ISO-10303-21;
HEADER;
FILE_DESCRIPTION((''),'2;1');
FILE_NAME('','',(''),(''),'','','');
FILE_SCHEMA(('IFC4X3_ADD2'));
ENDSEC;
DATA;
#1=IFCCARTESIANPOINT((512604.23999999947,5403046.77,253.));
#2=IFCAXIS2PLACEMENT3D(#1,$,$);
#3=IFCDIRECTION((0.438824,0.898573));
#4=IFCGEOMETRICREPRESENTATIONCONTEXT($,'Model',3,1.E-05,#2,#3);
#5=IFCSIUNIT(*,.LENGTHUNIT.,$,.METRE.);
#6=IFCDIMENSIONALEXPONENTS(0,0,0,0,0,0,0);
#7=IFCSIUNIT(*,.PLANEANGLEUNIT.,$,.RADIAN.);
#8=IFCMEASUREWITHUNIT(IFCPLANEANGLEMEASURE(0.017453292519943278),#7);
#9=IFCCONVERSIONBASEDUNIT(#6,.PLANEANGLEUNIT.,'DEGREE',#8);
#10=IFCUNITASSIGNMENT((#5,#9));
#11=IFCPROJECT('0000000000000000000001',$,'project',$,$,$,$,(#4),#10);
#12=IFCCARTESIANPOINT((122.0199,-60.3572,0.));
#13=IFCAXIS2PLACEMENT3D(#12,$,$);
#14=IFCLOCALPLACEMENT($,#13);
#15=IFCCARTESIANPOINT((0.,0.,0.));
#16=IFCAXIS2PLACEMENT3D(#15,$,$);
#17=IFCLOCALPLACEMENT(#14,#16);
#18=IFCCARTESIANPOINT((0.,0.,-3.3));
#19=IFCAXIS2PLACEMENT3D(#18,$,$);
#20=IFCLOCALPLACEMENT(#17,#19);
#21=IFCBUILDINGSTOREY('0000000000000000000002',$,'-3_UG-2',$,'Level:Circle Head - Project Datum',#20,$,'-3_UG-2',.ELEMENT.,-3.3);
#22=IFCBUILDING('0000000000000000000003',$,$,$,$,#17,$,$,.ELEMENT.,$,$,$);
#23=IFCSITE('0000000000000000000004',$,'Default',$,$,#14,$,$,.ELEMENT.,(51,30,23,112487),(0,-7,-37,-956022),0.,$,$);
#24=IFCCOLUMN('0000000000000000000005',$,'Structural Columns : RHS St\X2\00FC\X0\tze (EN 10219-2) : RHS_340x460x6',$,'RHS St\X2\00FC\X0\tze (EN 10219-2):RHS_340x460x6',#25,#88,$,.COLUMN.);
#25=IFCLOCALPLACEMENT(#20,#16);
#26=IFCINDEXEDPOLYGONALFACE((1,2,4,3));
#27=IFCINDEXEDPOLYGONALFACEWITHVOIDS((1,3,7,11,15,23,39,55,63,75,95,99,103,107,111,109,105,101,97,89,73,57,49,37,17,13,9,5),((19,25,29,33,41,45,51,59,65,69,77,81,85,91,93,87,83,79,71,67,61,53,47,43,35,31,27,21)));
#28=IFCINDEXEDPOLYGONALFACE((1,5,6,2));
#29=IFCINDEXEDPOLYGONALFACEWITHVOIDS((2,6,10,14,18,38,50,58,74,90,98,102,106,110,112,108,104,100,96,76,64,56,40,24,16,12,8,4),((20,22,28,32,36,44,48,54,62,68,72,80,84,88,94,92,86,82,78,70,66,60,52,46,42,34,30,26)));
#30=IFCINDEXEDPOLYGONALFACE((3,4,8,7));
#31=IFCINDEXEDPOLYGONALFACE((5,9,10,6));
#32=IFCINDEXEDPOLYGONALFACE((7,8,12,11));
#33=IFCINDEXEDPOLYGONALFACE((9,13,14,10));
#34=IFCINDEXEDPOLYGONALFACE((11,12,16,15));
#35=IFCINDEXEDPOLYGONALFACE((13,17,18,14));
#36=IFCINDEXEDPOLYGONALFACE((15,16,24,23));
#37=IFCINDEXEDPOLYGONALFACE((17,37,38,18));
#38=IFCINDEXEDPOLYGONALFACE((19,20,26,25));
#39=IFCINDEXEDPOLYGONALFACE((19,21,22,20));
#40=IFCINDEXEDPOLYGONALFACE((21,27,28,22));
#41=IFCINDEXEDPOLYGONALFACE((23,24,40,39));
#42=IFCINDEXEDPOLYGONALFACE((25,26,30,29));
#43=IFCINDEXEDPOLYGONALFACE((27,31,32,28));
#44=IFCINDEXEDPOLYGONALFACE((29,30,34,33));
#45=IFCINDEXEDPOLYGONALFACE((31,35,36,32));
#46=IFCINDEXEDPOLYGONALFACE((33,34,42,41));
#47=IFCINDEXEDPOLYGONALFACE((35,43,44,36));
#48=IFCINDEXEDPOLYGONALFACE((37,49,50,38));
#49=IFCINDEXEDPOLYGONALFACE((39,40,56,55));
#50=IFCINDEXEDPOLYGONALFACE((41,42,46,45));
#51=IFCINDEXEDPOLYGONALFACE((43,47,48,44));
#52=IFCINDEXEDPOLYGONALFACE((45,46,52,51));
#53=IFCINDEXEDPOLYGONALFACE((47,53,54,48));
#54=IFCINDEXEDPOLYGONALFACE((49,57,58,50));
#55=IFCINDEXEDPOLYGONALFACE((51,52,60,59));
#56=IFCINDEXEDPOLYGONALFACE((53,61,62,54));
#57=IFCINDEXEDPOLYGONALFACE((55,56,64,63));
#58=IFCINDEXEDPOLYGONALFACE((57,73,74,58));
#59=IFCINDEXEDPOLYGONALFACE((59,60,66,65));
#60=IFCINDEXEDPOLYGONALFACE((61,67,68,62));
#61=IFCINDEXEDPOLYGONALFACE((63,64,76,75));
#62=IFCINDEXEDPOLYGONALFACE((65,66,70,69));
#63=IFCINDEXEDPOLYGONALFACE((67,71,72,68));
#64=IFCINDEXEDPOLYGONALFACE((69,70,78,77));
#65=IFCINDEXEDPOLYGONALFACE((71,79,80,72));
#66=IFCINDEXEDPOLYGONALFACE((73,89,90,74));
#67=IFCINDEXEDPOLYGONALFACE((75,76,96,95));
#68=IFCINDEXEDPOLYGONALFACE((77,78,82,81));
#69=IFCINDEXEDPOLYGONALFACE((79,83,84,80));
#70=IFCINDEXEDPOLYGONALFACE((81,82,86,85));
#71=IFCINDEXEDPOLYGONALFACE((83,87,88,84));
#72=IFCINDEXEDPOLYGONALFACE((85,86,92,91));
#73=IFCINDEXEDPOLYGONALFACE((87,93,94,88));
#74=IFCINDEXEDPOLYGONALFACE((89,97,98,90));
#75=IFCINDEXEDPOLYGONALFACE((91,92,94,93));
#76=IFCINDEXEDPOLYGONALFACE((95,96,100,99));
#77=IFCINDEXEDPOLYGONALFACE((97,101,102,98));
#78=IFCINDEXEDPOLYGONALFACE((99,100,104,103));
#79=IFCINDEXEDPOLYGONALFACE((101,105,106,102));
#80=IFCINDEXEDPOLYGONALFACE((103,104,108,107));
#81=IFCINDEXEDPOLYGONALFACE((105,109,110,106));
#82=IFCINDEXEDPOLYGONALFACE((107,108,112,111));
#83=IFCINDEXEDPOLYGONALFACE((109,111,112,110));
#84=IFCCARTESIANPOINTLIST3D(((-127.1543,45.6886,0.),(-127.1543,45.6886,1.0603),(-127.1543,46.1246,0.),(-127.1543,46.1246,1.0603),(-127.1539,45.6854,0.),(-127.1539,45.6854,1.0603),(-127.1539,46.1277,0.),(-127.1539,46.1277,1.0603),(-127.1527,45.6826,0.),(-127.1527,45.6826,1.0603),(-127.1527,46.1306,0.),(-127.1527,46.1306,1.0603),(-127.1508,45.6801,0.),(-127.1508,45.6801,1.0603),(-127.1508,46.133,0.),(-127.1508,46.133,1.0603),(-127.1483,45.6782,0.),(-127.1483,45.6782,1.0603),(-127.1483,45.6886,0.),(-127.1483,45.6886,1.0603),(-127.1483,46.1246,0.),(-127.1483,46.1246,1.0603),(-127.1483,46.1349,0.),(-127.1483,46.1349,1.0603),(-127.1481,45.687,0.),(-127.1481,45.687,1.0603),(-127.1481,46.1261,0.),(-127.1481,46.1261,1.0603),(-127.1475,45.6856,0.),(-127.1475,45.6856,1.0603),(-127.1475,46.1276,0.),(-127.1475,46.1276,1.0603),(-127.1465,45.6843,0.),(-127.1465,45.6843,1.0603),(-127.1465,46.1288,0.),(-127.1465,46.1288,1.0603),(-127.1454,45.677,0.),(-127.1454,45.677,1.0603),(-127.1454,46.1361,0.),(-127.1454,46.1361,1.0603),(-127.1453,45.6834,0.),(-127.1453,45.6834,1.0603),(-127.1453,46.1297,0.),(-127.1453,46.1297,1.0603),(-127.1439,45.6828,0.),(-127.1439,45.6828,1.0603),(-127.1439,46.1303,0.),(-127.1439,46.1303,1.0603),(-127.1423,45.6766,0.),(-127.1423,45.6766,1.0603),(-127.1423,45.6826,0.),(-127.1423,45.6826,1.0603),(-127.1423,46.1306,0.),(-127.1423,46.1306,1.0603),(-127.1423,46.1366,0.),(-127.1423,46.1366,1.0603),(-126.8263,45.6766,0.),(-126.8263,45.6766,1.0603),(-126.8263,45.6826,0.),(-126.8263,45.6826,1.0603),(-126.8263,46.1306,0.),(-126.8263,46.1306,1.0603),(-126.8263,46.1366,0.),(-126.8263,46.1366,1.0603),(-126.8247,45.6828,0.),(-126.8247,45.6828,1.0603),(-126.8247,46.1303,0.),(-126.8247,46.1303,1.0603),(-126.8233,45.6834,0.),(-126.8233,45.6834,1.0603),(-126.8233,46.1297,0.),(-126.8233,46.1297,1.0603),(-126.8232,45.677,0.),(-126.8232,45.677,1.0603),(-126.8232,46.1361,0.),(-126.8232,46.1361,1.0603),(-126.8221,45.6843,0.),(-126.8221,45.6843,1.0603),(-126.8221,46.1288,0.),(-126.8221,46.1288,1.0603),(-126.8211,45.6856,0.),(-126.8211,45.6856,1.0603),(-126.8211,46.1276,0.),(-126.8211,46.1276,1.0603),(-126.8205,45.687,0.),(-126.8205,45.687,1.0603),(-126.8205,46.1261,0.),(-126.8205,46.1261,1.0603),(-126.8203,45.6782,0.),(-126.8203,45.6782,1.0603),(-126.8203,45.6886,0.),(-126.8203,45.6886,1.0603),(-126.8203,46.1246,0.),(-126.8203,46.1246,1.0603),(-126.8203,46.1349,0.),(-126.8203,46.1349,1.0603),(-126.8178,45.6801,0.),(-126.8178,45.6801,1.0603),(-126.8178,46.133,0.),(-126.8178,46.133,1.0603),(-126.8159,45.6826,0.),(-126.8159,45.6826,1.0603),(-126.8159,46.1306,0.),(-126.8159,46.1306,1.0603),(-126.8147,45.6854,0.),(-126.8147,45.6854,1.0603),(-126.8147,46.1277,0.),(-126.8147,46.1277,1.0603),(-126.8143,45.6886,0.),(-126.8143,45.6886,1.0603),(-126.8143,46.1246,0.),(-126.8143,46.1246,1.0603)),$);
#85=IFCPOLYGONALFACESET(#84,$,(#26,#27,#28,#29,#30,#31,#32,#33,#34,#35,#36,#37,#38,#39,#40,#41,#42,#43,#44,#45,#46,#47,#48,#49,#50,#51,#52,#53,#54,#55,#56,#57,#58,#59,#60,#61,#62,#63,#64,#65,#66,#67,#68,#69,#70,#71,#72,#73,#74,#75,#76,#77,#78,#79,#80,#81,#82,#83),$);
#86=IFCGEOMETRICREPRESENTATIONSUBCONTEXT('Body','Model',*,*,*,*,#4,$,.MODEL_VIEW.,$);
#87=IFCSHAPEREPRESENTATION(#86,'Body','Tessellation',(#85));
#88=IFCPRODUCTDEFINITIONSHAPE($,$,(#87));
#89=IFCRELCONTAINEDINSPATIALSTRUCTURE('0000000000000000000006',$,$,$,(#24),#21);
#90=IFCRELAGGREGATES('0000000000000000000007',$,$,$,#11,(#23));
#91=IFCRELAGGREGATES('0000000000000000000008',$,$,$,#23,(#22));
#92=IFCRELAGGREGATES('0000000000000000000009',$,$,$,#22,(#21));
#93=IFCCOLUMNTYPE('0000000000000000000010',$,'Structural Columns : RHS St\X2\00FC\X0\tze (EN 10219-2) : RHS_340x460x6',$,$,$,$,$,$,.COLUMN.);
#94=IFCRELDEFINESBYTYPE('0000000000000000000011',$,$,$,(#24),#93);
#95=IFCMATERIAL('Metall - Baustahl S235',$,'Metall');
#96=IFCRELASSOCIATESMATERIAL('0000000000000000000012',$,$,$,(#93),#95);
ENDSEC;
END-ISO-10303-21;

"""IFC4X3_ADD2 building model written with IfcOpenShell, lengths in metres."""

from ifc_helpers import new_model, entity, si_unit, converted_unit, direction, frame, frame_2d, origin, place, context, subcontext, project, spatial, polyline, circle_curve, parameter, trimmed, segment, composite_curve, outline, extrude, source, transform, mapped, material, material_profile, profile_set, type_object, type_shapes, element, save


model = new_model("IFC4X3_ADD2")

# Units and contexts
model_context = context("Model", 3, precision=1e-05, world=frame((512604.23999999947, 5403046.77, 253.0)), true_north=direction((0.438824, 0.898573)))
body_context = subcontext(model_context, "Body", "Model", "MODEL_VIEW")
ifc_project = project(units=[si_unit("LENGTHUNIT", "METRE"), converted_unit("PLANEANGLEUNIT", "DEGREE", entity("IfcPlaneAngleMeasure", 0.017453292519943278), si_unit("PLANEANGLEUNIT", "RADIAN"), dimensions=[0, 0, 0, 0, 0, 0, 0])], contexts=[model_context])

# Site, building, storey
site_placement = place(None, frame((122.0199, -60.3572, 0.0)))
site = spatial("IfcSite", under=ifc_project, at=site_placement, Name="Default", CompositionType="ELEMENT", RefLatitude=(51, 30, 23, 112487), RefLongitude=(0, -7, -37, -956022), RefElevation=0.0)
building_placement = place(site_placement, origin())
building = spatial("IfcBuilding", under=site, at=building_placement, CompositionType="ELEMENT")
storey_placement = place(building_placement, frame((0.0, 0.0, -3.3)))
storey = spatial("IfcBuildingStorey", under=building, at=storey_placement, Name="-3_UG-2", ObjectType="Level:Circle Head - Project Datum", LongName="-3_UG-2", CompositionType="ELEMENT", Elevation=-3.3)

# Column
ifc_material_1 = material(Name="Metall - Baustahl S235", Category="Metall")
ifc_material_profile_1 = material_profile(ifc_material_1, outline(composite_curve([segment(polyline([(-0.158, -0.23), (0.158, -0.23)]), True, "CONTINUOUS"), segment(trimmed(circle_curve(frame_2d((0.158, -0.218), x_axis=(-1.0, 0.0)), 0.012), [parameter(90.0)], [parameter(180.0)], True, "PARAMETER"), True, "CONTINUOUS"), segment(polyline([(0.17, -0.218), (0.17, 0.218)]), True, "CONTINUOUS"), segment(trimmed(circle_curve(frame_2d((0.158, 0.218), x_axis=(-1.0, 0.0)), 0.012), [parameter(180.0)], [parameter(270.0)], True, "PARAMETER"), True, "CONTINUOUS"), segment(polyline([(0.158, 0.23), (-0.158, 0.23)]), True, "CONTINUOUS"), segment(trimmed(circle_curve(frame_2d((-0.158, 0.218), x_axis=(-1.0, 0.0)), 0.012), [parameter(270.0)], [parameter(360.0)], True, "PARAMETER"), True, "CONTINUOUS"), segment(polyline([(-0.17, 0.218), (-0.17, -0.218)]), True, "CONTINUOUS"), segment(trimmed(circle_curve(frame_2d((-0.158, -0.218), x_axis=(-1.0, 0.0)), 0.012), [parameter(360.0)], [parameter(90.0)], True, "PARAMETER"), True, "CONTINUOUS")], self_intersect=False), holes=[composite_curve([segment(trimmed(circle_curve(frame_2d((-0.158, -0.218), x_axis=(-1.0, 0.0)), 0.006), [parameter(0.0)], [parameter(90.0)], True, "PARAMETER"), False, "CONTINUOUS"), segment(polyline([(-0.164, -0.218), (-0.164, 0.218)]), True, "CONTINUOUS"), segment(trimmed(circle_curve(frame_2d((-0.158, 0.218), x_axis=(-1.0, 0.0)), 0.006), [parameter(270.0)], [parameter(360.0)], True, "PARAMETER"), False, "CONTINUOUS"), segment(polyline([(-0.158, 0.224), (0.158, 0.224)]), True, "CONTINUOUS"), segment(trimmed(circle_curve(frame_2d((0.158, 0.218), x_axis=(-1.0, 0.0)), 0.006), [parameter(180.0)], [parameter(270.0)], True, "PARAMETER"), False, "CONTINUOUS"), segment(polyline([(0.164, 0.218), (0.164, -0.218)]), True, "CONTINUOUS"), segment(trimmed(circle_curve(frame_2d((0.158, -0.218), x_axis=(-1.0, 0.0)), 0.006), [parameter(90.0)], [parameter(180.0)], True, "PARAMETER"), False, "CONTINUOUS"), segment(polyline([(0.158, -0.224), (-0.158, -0.224)]), True, "CONTINUOUS")], self_intersect=False)]), Name="RHS_340x460x6")
ifc_profile_set_1 = profile_set([ifc_material_profile_1], Name="RHS_340x460x6")
column_type_1 = type_object("IfcColumnType", Name="Structural Columns : RHS Stütze (EN 10219-2) : RHS_340x460x6", PredefinedType="COLUMN", material=ifc_profile_set_1)
shared_shape_1 = source(origin(), body_context, "Body", "SweptSolid", [
    extrude(outline(composite_curve([segment(polyline([(-0.158, -0.23), (0.158, -0.23)]), True, "CONTINUOUS"), segment(trimmed(circle_curve(frame_2d((0.158, -0.218), x_axis=(-1.0, 0.0)), 0.012), [parameter(90.0)], [parameter(180.0)], True, "PARAMETER"), True, "CONTINUOUS"), segment(polyline([(0.17, -0.218), (0.17, 0.218)]), True, "CONTINUOUS"), segment(trimmed(circle_curve(frame_2d((0.158, 0.218), x_axis=(-1.0, 0.0)), 0.012), [parameter(180.0)], [parameter(270.0)], True, "PARAMETER"), True, "CONTINUOUS"), segment(polyline([(0.158, 0.23), (-0.158, 0.23)]), True, "CONTINUOUS"), segment(trimmed(circle_curve(frame_2d((-0.158, 0.218), x_axis=(-1.0, 0.0)), 0.012), [parameter(270.0)], [parameter(360.0)], True, "PARAMETER"), True, "CONTINUOUS"), segment(polyline([(-0.17, 0.218), (-0.17, -0.218)]), True, "CONTINUOUS"), segment(trimmed(circle_curve(frame_2d((-0.158, -0.218), x_axis=(-1.0, 0.0)), 0.012), [parameter(360.0)], [parameter(90.0)], True, "PARAMETER"), True, "CONTINUOUS")], self_intersect=False), holes=[composite_curve([segment(trimmed(circle_curve(frame_2d((-0.158, -0.218), x_axis=(-1.0, 0.0)), 0.006), [parameter(0.0)], [parameter(90.0)], True, "PARAMETER"), False, "CONTINUOUS"), segment(polyline([(-0.164, -0.218), (-0.164, 0.218)]), True, "CONTINUOUS"), segment(trimmed(circle_curve(frame_2d((-0.158, 0.218), x_axis=(-1.0, 0.0)), 0.006), [parameter(270.0)], [parameter(360.0)], True, "PARAMETER"), False, "CONTINUOUS"), segment(polyline([(-0.158, 0.224), (0.158, 0.224)]), True, "CONTINUOUS"), segment(trimmed(circle_curve(frame_2d((0.158, 0.218), x_axis=(-1.0, 0.0)), 0.006), [parameter(180.0)], [parameter(270.0)], True, "PARAMETER"), False, "CONTINUOUS"), segment(polyline([(0.164, 0.218), (0.164, -0.218)]), True, "CONTINUOUS"), segment(trimmed(circle_curve(frame_2d((0.158, -0.218), x_axis=(-1.0, 0.0)), 0.006), [parameter(90.0)], [parameter(180.0)], True, "PARAMETER"), False, "CONTINUOUS"), segment(polyline([(0.158, -0.224), (-0.158, -0.224)]), True, "CONTINUOUS")], self_intersect=False)]), frame((0.0, 0.0, -3.3), z_axis=(0.0, 0.0, 1.0), x_axis=(-1.0, 0.0, 0.0)), (0.0, 0.0, 1.0), 1.0603),
])
type_shapes(column_type_1, [shared_shape_1])
column_1_placement = place(storey_placement, frame((-126.9843, 45.9066, 3.3)))
element("IfcColumn", 1, at=column_1_placement, inside=storey, type_object=column_type_1, Name="Structural Columns : RHS Stütze (EN 10219-2) : RHS_340x460x6", ObjectType="RHS Stütze (EN 10219-2):RHS_340x460x6", PredefinedType="COLUMN", context=body_context, shape_type="MappedRepresentation", body=[
    mapped(shared_shape_1, transform((0.0, 0.0, 0.0), scale=1.0)),
])

save(model, "model.ifc")
